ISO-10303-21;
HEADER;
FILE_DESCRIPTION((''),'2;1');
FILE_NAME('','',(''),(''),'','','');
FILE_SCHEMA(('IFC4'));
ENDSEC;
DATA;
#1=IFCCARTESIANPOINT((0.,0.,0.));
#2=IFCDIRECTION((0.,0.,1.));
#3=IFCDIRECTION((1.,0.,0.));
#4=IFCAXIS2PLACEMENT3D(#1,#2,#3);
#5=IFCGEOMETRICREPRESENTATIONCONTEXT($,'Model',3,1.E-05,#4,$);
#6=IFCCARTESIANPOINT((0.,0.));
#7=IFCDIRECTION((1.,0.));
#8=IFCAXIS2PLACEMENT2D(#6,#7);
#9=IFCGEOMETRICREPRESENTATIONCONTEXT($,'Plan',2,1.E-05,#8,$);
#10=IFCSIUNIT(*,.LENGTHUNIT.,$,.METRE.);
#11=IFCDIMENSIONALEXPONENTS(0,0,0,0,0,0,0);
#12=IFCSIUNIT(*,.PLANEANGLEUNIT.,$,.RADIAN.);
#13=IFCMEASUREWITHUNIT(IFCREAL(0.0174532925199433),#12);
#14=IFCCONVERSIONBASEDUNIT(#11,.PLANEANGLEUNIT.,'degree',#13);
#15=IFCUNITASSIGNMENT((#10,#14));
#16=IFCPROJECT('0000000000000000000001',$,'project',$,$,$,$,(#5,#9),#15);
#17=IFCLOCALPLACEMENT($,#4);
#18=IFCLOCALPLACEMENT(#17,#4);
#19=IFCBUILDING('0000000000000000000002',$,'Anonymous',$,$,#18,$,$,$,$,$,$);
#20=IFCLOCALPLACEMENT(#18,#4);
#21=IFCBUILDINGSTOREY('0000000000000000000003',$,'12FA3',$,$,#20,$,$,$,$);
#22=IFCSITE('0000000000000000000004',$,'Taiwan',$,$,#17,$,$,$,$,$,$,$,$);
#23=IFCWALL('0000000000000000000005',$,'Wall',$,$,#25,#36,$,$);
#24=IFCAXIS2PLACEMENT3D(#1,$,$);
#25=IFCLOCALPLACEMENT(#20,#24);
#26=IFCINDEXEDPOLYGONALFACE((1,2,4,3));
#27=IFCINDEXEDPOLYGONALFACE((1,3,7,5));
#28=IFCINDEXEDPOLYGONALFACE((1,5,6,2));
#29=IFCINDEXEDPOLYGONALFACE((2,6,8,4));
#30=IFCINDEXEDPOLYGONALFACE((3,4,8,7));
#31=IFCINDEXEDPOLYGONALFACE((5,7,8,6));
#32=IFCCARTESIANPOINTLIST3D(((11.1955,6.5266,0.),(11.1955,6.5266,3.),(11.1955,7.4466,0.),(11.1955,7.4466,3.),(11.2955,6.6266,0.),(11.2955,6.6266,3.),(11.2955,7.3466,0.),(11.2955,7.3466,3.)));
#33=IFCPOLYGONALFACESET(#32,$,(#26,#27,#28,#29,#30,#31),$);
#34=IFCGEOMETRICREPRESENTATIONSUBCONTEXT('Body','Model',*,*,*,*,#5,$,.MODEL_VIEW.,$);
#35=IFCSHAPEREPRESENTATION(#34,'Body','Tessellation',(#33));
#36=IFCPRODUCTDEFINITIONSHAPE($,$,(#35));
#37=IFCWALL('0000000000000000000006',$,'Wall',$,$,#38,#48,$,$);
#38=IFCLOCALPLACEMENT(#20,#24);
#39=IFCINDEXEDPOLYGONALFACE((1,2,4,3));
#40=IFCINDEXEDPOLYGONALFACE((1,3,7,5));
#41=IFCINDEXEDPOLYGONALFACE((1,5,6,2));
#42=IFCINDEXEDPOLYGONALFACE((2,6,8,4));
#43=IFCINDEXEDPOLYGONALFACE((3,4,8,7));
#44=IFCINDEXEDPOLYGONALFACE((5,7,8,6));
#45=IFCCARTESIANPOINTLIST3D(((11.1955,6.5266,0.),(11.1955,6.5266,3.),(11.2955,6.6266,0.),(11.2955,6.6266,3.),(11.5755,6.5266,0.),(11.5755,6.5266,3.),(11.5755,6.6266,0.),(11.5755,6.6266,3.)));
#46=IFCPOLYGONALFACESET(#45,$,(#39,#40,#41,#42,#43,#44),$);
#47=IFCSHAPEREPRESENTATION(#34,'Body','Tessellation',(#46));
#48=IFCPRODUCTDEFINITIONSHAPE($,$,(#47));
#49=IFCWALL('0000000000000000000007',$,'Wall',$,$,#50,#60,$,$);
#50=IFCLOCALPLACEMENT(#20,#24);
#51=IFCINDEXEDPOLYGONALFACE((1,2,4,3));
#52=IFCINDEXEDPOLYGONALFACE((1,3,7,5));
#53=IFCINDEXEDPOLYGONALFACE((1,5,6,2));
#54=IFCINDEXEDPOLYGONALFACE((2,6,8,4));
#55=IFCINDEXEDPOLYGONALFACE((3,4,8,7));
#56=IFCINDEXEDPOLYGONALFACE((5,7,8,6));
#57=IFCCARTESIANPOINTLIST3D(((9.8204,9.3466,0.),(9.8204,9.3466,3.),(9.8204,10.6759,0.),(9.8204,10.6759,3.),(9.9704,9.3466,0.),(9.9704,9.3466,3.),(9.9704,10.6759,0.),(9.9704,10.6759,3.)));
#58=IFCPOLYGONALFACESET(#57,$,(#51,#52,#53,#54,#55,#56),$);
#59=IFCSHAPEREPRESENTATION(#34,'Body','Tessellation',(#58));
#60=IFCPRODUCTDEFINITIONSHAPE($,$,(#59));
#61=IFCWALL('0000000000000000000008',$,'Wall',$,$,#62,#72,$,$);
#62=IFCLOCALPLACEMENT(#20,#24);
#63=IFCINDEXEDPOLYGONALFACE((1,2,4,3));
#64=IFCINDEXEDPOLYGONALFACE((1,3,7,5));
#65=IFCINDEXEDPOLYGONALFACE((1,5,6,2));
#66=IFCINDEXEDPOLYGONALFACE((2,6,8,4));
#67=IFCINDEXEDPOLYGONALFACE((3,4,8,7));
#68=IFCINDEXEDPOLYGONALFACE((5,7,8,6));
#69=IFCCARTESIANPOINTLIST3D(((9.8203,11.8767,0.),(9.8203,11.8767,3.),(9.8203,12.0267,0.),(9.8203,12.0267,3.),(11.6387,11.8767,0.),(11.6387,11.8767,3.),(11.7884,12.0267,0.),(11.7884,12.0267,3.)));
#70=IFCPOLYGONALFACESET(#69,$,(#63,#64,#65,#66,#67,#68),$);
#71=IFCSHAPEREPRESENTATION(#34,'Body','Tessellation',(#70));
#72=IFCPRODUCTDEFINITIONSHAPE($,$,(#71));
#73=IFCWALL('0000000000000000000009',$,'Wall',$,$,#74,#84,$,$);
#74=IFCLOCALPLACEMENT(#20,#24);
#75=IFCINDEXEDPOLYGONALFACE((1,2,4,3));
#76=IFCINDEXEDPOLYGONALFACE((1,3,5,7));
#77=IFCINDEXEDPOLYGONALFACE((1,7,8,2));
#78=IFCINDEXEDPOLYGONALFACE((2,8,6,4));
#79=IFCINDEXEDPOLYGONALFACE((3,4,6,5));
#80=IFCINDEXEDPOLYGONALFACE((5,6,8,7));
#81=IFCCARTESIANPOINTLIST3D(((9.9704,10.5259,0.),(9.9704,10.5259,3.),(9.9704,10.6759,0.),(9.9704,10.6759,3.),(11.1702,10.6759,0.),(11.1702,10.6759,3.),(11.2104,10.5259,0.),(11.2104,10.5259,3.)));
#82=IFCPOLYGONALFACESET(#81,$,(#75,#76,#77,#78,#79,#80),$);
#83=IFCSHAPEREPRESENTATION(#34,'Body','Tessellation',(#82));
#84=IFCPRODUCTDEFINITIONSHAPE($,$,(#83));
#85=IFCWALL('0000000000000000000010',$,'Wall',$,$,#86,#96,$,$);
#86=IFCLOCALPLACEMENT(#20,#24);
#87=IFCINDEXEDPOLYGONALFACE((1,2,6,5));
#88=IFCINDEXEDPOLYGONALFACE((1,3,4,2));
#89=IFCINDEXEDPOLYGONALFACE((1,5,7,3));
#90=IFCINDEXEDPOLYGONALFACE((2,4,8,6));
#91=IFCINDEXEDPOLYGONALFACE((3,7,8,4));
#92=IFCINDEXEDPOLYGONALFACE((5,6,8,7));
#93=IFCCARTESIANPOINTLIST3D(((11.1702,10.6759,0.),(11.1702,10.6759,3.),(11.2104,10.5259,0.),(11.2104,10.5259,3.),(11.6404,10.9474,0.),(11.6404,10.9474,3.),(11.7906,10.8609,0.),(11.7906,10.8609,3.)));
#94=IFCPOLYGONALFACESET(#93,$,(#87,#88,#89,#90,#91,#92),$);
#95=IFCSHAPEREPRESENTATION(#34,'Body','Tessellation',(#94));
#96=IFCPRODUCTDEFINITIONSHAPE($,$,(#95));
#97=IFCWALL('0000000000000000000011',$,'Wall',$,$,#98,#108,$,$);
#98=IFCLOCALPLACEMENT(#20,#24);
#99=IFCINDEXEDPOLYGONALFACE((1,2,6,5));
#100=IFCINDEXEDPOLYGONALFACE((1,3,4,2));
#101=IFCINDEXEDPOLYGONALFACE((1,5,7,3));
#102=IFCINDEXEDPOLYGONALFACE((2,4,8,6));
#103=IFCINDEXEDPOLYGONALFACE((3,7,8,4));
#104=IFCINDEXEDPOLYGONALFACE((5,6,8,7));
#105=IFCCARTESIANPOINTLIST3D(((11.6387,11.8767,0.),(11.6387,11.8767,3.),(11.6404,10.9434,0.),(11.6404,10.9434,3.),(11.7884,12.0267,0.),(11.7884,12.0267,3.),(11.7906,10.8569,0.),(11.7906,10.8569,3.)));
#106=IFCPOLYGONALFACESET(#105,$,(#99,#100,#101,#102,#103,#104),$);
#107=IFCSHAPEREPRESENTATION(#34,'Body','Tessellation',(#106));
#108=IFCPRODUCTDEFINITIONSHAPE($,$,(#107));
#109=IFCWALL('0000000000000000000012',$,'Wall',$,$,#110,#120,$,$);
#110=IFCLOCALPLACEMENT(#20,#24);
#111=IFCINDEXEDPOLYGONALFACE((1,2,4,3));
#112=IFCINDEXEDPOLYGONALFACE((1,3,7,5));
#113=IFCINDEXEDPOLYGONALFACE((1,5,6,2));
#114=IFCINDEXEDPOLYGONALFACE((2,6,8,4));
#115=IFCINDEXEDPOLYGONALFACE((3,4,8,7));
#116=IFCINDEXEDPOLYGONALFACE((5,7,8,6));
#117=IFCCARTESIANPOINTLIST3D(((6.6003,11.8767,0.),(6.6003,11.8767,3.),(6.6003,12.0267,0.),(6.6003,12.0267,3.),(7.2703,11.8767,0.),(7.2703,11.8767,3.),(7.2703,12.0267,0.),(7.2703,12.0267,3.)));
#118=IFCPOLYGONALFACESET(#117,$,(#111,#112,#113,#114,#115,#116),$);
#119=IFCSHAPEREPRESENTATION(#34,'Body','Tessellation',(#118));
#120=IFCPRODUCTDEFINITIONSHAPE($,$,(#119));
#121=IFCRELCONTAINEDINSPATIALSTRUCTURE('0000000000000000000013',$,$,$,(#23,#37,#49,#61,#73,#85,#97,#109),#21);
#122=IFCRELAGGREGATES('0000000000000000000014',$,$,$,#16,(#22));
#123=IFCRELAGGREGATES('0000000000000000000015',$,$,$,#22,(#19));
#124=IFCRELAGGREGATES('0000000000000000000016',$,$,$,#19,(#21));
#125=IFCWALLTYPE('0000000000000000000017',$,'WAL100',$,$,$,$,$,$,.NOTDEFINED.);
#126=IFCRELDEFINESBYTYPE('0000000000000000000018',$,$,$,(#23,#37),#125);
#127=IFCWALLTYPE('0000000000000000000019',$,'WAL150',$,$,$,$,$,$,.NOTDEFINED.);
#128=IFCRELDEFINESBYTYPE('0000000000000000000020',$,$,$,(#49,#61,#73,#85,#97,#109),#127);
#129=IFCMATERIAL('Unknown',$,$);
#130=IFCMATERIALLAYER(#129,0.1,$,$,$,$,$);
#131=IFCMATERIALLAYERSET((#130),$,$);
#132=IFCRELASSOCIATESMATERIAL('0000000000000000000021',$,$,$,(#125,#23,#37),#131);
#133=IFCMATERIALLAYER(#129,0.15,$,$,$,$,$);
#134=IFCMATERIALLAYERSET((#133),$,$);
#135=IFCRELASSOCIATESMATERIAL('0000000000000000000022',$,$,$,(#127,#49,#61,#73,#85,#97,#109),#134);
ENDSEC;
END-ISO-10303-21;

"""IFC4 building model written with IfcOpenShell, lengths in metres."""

from ifc_helpers import new_model, entity, si_unit, converted_unit, frame, origin_with_axes, origin_2d_with_axis, place, context, subcontext, project, spatial, line, indexed_curve, outline, extrude, material, layer, layer_set, layer_usage, type_object, element, save


model = new_model("IFC4")

# Units and contexts
model_context = context("Model", 3, precision=1e-05, world=origin_with_axes())
plan_context = context("Plan", 2, precision=1e-05, world=origin_2d_with_axis())
body_context_1 = subcontext(model_context, "Body", "Model", "MODEL_VIEW")
ifc_project = project(units=[si_unit("LENGTHUNIT", "METRE"), converted_unit("PLANEANGLEUNIT", "degree", entity("IfcReal", 0.0174532925199433), si_unit("PLANEANGLEUNIT", "RADIAN"), dimensions=[0, 0, 0, 0, 0, 0, 0])], contexts=[model_context, plan_context])

# Site, building, storey
site_placement = place(None, origin_with_axes())
site = spatial("IfcSite", under=ifc_project, at=site_placement, Name="Taiwan")
building_placement = place(site_placement, origin_with_axes())
building = spatial("IfcBuilding", under=site, at=building_placement, Name="Anonymous")
storey_placement = place(building_placement, origin_with_axes())
storey = spatial("IfcBuildingStorey", under=building, at=storey_placement, Name="12FA3")

# Shared definitions
ifc_material = material(Name="Unknown")

# Shared definitions
ifc_layer_1 = layer(ifc_material, 0.1)
ifc_layer_set_1 = layer_set([ifc_layer_1])
wall_type_1 = type_object("IfcWallType", Name="WAL100", PredefinedType="NOTDEFINED", material=ifc_layer_set_1)

# Walls
ifc_layer_usage_1 = layer_usage(ifc_layer_set_1, "AXIS2", "POSITIVE", 0.0)
wall_1_placement = place(storey_placement, frame((11.1955, 7.4466, 0.0), z_axis=(0.0, 0.0, 1.0), x_axis=(0.0, -1.0, 0.0)))
element("IfcWall", 1, at=wall_1_placement, inside=storey, type_object=wall_type_1, material=ifc_layer_usage_1, Name="Wall", context=body_context_1, shape_type="SweptSolid", body=[
    extrude(outline(indexed_curve([(0.0, 0.0), (0.1, 0.1), (0.82, 0.1), (0.92, 0.0)], segments=[line(1, 2, 3, 4, 1)])), origin_with_axes(), (0.0, 0.0, 1.0), 3.0),
])
ifc_layer_usage_2 = layer_usage(ifc_layer_set_1, "AXIS2", "POSITIVE", 0.0)
wall_2_placement = place(storey_placement, frame((11.1955, 6.5266, 0.0), z_axis=(0.0, 0.0, 1.0), x_axis=(1.0, 0.0, 0.0)))
element("IfcWall", 2, at=wall_2_placement, inside=storey, type_object=wall_type_1, material=ifc_layer_usage_2, Name="Wall", context=body_context_1, shape_type="SweptSolid", body=[
    extrude(outline(indexed_curve([(0.0, 0.0), (0.1, 0.1), (0.38, 0.1), (0.38, 0.0)], segments=[line(1, 2, 3, 4, 1)])), origin_with_axes(), (0.0, 0.0, 1.0), 3.0),
])
ifc_layer_2 = layer(ifc_material, 0.15)
ifc_layer_set_2 = layer_set([ifc_layer_2])
wall_type_2 = type_object("IfcWallType", Name="WAL150", PredefinedType="NOTDEFINED", material=ifc_layer_set_2)
ifc_layer_usage_3 = layer_usage(ifc_layer_set_2, "AXIS2", "POSITIVE", 0.0)
wall_3_placement = place(storey_placement, frame((9.9704, 9.3466, 0.0), z_axis=(0.0, 0.0, 1.0), x_axis=(0.0, 1.0, 0.0)))
element("IfcWall", 3, at=wall_3_placement, inside=storey, type_object=wall_type_2, material=ifc_layer_usage_3, Name="Wall", context=body_context_1, shape_type="SweptSolid", body=[
    extrude(outline(indexed_curve([(0.0, 0.0), (0.0, 0.15), (1.3293, 0.15), (1.3293, 0.0)], segments=[line(1, 2, 3, 4, 1)])), origin_with_axes(), (0.0, 0.0, 1.0), 3.0),
])
ifc_layer_usage_4 = layer_usage(ifc_layer_set_2, "AXIS2", "POSITIVE", 0.0)
wall_4_placement = place(storey_placement, frame((11.7884, 12.0267, 0.0), z_axis=(0.0, 0.0, 1.0), x_axis=(-1.0, 0.0, 0.0)))
element("IfcWall", 4, at=wall_4_placement, inside=storey, type_object=wall_type_2, material=ifc_layer_usage_4, Name="Wall", context=body_context_1, shape_type="SweptSolid", body=[
    extrude(outline(indexed_curve([(0.0, 0.0), (0.1497, 0.15), (1.9681, 0.15), (1.9681, 0.0)], segments=[line(1, 2, 3, 4, 1)])), origin_with_axes(), (0.0, 0.0, 1.0), 3.0),
])
ifc_layer_usage_5 = layer_usage(ifc_layer_set_2, "AXIS2", "POSITIVE", 0.0)
wall_5_placement = place(storey_placement, frame((9.9704, 10.5259, 0.0), z_axis=(0.0, 0.0, 1.0), x_axis=(1.0, 0.0, 0.0)))
element("IfcWall", 5, at=wall_5_placement, inside=storey, type_object=wall_type_2, material=ifc_layer_usage_5, Name="Wall", context=body_context_1, shape_type="SweptSolid", body=[
    extrude(outline(indexed_curve([(0.0, 0.0), (0.0, 0.15), (1.1998, 0.15), (1.24, 0.0)], segments=[line(1, 2, 3, 4, 1)])), origin_with_axes(), (0.0, 0.0, 1.0), 3.0),
])
ifc_layer_usage_6 = layer_usage(ifc_layer_set_2, "AXIS2", "POSITIVE", 0.0)
wall_6_placement = place(storey_placement, frame((11.2104, 10.5259, 0.0), z_axis=(0.0, 0.0, 1.0), x_axis=(0.866026, 0.5, 0.0)))
element("IfcWall", 6, at=wall_6_placement, inside=storey, type_object=wall_type_2, material=ifc_layer_usage_6, Name="Wall", context=body_context_1, shape_type="SweptSolid", body=[
    extrude(outline(indexed_curve([(0.0, 0.0), (0.0402, 0.15), (0.5832, 0.15), (0.67, 0.0)], segments=[line(1, 2, 3, 4, 1)])), origin_with_axes(), (0.0, 0.0, 1.0), 3.0),
])
ifc_layer_usage_7 = layer_usage(ifc_layer_set_2, "AXIS2", "POSITIVE", 0.0)
wall_7_placement = place(storey_placement, frame((11.7906, 10.8569, 0.0), z_axis=(0.0, 0.0, 1.0), x_axis=(-0.001882, 0.999998, 0.0)))
element("IfcWall", 7, at=wall_7_placement, inside=storey, type_object=wall_type_2, material=ifc_layer_usage_7, Name="Wall", context=body_context_1, shape_type="SweptSolid", body=[
    extrude(outline(indexed_curve([(0.0, 0.0), (0.0868, 0.15), (1.02, 0.15), (1.1698, 0.0)], segments=[line(1, 2, 3, 4, 1)])), origin_with_axes(), (0.0, 0.0, 1.0), 3.0),
])
ifc_layer_usage_8 = layer_usage(ifc_layer_set_2, "AXIS2", "POSITIVE", 0.0)
wall_8_placement = place(storey_placement, frame((7.2703, 12.0267, 0.0), z_axis=(0.0, 0.0, 1.0), x_axis=(-1.0, 0.0, 0.0)))
element("IfcWall", 8, at=wall_8_placement, inside=storey, type_object=wall_type_2, material=ifc_layer_usage_8, Name="Wall", context=body_context_1, shape_type="SweptSolid", body=[
    extrude(outline(indexed_curve([(0.0, 0.0), (0.0, 0.15), (0.67, 0.15), (0.67, 0.0)], segments=[line(1, 2, 3, 4, 1)])), origin_with_axes(), (0.0, 0.0, 1.0), 3.0),
])

save(model, "model.ifc")
